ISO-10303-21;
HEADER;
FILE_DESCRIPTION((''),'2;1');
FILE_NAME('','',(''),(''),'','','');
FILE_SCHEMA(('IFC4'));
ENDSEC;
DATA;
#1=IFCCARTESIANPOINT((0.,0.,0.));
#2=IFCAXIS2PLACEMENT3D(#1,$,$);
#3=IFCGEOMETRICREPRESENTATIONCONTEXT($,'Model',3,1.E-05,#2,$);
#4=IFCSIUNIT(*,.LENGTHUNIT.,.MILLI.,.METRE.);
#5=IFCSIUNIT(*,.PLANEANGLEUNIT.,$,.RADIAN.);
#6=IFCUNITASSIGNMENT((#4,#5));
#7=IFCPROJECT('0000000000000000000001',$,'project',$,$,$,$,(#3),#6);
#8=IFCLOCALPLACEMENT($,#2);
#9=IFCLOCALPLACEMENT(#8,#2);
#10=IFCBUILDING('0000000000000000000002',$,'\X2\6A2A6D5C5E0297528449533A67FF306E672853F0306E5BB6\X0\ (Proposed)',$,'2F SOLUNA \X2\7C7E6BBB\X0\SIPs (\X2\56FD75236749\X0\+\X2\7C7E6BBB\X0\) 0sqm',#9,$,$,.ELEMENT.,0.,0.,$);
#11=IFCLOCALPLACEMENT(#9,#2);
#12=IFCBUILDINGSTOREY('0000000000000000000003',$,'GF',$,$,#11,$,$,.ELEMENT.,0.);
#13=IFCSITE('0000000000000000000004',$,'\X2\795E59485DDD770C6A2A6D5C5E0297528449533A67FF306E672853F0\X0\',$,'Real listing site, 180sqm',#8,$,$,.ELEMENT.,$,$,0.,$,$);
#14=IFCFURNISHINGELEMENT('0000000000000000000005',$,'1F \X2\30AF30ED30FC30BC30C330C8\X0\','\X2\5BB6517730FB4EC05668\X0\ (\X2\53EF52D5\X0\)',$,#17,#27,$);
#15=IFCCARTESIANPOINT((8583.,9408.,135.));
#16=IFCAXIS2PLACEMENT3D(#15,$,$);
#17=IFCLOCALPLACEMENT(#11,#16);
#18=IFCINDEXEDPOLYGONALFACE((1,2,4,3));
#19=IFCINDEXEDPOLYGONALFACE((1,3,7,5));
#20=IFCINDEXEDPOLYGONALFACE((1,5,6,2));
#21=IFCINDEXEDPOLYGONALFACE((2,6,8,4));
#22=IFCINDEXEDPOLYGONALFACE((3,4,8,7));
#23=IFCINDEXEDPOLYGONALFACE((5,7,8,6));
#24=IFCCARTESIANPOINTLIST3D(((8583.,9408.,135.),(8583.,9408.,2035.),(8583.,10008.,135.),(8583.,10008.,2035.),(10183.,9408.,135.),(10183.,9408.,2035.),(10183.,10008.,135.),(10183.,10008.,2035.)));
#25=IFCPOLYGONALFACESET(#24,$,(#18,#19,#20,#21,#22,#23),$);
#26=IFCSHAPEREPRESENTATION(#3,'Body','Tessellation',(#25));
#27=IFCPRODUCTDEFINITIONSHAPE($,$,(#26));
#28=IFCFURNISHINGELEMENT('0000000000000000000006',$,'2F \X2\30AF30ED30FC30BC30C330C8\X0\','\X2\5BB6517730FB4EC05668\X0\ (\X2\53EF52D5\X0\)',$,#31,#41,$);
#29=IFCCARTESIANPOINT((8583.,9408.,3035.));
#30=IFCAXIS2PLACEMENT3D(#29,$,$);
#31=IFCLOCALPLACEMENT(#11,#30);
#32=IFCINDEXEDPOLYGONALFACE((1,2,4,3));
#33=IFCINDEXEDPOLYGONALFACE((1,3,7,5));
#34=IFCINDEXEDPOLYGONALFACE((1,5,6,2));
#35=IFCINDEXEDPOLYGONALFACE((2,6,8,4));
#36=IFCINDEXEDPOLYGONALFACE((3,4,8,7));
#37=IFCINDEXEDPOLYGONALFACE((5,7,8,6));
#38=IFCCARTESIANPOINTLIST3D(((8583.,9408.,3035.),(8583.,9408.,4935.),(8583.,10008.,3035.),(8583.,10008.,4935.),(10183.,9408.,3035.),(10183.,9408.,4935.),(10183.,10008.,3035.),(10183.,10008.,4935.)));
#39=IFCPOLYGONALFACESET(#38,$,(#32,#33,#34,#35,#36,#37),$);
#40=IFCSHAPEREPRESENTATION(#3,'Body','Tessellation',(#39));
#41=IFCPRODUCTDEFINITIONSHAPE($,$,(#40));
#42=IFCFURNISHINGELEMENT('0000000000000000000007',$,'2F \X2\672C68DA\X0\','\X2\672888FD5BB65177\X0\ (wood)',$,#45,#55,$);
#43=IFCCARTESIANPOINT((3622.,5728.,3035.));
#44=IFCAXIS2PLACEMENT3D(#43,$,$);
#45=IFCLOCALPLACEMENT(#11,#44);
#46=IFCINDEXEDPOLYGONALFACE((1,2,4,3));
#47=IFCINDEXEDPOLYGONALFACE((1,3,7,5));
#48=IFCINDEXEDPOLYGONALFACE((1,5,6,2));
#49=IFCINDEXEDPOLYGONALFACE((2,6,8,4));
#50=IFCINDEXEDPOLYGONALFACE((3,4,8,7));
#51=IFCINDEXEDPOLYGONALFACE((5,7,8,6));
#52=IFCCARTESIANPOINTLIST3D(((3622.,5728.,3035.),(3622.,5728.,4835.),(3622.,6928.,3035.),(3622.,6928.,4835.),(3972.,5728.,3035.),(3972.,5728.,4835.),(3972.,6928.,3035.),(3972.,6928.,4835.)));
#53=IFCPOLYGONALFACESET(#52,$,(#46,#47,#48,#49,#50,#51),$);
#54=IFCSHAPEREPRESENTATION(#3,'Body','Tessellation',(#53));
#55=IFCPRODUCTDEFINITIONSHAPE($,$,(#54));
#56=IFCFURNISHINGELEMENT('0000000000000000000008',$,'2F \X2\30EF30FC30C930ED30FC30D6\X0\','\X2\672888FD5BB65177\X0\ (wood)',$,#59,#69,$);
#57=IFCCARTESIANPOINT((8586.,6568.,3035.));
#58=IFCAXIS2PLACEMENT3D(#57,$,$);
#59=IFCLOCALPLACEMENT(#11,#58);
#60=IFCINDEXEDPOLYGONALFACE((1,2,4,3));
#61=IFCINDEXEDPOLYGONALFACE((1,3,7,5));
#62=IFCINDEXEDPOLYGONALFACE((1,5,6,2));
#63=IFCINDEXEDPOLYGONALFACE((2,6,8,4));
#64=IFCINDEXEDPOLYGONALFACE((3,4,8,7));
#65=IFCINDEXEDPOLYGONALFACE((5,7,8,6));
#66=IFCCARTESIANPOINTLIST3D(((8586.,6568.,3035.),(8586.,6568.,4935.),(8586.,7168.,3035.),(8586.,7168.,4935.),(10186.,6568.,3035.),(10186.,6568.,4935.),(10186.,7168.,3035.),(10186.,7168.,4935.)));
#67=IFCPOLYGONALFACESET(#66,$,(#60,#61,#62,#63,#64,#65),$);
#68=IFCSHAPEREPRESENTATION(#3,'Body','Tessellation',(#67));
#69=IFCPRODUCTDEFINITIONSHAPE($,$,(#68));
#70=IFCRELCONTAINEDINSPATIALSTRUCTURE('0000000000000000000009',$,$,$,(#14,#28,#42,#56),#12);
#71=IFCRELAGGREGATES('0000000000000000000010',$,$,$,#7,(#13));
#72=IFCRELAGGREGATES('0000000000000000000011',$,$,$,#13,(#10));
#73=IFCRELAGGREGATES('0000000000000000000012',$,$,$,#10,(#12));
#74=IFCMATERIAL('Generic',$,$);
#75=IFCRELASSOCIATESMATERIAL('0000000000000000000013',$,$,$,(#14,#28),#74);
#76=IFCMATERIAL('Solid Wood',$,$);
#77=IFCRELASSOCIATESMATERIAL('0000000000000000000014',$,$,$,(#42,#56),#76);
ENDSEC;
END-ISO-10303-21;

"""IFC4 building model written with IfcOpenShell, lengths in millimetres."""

from ifc_helpers import new_model, si_unit, frame, frame_2d, origin, place, context, project, spatial, rectangle, extrude, material, element, save


model = new_model("IFC4")

# Units and contexts
model_context = context("Model", 3, precision=1e-05, world=origin())
ifc_project = project(units=[si_unit("LENGTHUNIT", "METRE", prefix="MILLI"), si_unit("PLANEANGLEUNIT", "RADIAN")], contexts=[model_context])

# Site, building, storey
site_placement = place(None, origin())
site = spatial("IfcSite", under=ifc_project, at=site_placement, Name="神奈川県横浜市青葉区柿の木台", ObjectType="Real listing site, 180sqm", CompositionType="ELEMENT", RefElevation=0.0)
building_placement = place(site_placement, origin())
building = spatial("IfcBuilding", under=site, at=building_placement, Name="横浜市青葉区柿の木台の家 (Proposed)", ObjectType="2F SOLUNA 籾殻SIPs (国産杉+籾殻) 0sqm", CompositionType="ELEMENT", ElevationOfRefHeight=0.0, ElevationOfTerrain=0.0)
storey_placement = place(building_placement, origin())
storey = spatial("IfcBuildingStorey", under=building, at=storey_placement, Name="GF", CompositionType="ELEMENT", Elevation=0.0)

# Shared definitions
ifc_material_1 = material(Name="Solid Wood")

# Shared definitions
ifc_material_2 = material(Name="Generic")

# Furnishing elements
furnishing_1_placement = place(storey_placement, frame((8583.0, 9408.0, 135.0)))
element("IfcFurnishingElement", 1, at=furnishing_1_placement, inside=storey, material=ifc_material_2, Name="1F クローゼット", Description="家具・什器 (可動)", context=model_context, shape_type="SweptSolid", body=[
    extrude(rectangle(XDim=1600.0, YDim=600.0, at=frame_2d((800.0, 300.0))), frame((8583.0, 9408.0, 135.0)), (0.0, 0.0, 1.0), 1900.0),
])
furnishing_2_placement = place(storey_placement, frame((8583.0, 9408.0, 3035.0)))
element("IfcFurnishingElement", 2, at=furnishing_2_placement, inside=storey, material=ifc_material_2, Name="2F クローゼット", Description="家具・什器 (可動)", context=model_context, shape_type="SweptSolid", body=[
    extrude(rectangle(XDim=1600.0, YDim=600.0, at=frame_2d((800.0, 300.0))), frame((8583.0, 9408.0, 3035.0)), (0.0, 0.0, 1.0), 1900.0),
])
furnishing_3_placement = place(storey_placement, frame((3622.0, 5728.0, 3035.0)))
element("IfcFurnishingElement", 3, at=furnishing_3_placement, inside=storey, material=ifc_material_1, Name="2F 本棚", Description="木製家具 (wood)", context=model_context, shape_type="SweptSolid", body=[
    extrude(rectangle(XDim=350.0, YDim=1200.0, at=frame_2d((175.0, 600.0))), frame((3622.0, 5728.0, 3035.0)), (0.0, 0.0, 1.0), 1800.0),
])
furnishing_4_placement = place(storey_placement, frame((8586.0, 6568.0, 3035.0)))
element("IfcFurnishingElement", 4, at=furnishing_4_placement, inside=storey, material=ifc_material_1, Name="2F ワードローブ", Description="木製家具 (wood)", context=model_context, shape_type="SweptSolid", body=[
    extrude(rectangle(XDim=1600.0, YDim=600.0, at=frame_2d((800.0, 300.0))), frame((8586.0, 6568.0, 3035.0)), (0.0, 0.0, 1.0), 1900.0),
])

save(model, "model.ifc")
